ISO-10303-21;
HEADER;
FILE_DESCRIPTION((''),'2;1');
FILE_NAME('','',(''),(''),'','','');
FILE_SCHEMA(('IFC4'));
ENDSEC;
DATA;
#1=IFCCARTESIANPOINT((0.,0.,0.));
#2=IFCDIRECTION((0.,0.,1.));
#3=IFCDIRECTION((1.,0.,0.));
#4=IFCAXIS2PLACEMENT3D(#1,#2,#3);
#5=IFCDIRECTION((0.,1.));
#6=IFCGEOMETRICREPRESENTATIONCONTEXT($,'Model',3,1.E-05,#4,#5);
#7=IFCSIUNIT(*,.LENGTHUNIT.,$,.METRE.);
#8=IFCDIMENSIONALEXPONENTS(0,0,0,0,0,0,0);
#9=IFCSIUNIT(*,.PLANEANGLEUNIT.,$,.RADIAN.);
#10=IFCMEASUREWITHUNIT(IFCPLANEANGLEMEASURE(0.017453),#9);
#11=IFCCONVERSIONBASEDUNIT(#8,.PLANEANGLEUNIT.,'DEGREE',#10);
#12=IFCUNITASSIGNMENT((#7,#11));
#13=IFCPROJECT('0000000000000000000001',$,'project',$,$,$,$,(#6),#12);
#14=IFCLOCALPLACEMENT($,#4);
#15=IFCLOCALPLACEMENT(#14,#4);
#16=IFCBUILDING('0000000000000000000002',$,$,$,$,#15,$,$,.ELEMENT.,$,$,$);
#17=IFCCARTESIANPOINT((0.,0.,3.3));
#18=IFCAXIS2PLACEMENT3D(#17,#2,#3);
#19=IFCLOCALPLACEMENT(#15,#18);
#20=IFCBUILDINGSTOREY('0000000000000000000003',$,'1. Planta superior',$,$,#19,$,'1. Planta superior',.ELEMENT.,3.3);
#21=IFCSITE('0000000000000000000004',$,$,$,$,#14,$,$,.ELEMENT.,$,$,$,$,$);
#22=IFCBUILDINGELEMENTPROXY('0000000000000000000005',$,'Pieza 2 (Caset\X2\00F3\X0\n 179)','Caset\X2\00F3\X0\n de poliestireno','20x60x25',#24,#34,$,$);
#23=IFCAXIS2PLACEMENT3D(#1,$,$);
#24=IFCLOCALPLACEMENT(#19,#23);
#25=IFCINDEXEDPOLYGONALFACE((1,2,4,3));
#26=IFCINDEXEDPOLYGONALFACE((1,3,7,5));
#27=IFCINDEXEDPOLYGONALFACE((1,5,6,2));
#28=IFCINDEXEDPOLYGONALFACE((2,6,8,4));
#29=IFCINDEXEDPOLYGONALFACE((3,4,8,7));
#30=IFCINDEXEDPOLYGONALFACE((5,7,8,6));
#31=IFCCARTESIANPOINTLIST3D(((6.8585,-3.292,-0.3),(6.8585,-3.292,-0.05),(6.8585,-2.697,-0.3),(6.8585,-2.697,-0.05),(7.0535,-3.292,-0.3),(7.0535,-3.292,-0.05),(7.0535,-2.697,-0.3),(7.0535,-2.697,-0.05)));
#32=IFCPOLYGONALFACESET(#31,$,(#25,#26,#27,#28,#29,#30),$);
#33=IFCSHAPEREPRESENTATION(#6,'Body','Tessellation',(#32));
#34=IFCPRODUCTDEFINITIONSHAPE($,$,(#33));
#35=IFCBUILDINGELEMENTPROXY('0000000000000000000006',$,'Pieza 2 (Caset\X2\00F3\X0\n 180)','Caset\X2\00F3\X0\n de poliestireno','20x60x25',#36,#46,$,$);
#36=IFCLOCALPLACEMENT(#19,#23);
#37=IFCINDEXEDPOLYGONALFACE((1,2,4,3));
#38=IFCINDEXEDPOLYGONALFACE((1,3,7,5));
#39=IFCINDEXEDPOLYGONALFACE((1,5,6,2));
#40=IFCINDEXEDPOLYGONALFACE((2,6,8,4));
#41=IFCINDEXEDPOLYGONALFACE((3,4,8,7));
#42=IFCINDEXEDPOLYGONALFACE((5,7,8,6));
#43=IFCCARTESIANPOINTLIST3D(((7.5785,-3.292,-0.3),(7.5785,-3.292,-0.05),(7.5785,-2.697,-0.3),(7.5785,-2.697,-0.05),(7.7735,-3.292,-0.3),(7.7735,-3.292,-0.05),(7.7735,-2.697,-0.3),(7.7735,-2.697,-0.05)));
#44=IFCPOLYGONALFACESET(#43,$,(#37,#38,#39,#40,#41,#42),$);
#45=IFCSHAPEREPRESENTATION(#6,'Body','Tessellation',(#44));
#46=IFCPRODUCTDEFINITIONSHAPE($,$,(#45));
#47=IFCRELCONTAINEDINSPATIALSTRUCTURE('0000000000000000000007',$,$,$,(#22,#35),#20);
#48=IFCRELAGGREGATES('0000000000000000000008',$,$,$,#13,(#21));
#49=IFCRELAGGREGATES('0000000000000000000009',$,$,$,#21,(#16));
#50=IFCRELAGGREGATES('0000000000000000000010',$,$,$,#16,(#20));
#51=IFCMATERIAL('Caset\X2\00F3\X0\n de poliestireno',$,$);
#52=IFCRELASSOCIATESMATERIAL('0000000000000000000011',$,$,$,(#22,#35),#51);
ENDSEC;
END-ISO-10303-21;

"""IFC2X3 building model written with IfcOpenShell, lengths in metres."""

from ifc_helpers import new_model, entity, si_unit, converted_unit, direction, frame, origin_with_axes, origin_2d_with_axis, place, context, project, spatial, rectangle, extrude, source, transform, mapped, material, element, save


model = new_model("IFC2X3")

# Units and contexts
model_context = context("Model", 3, precision=1e-05, world=origin_with_axes(), true_north=direction((0.0, 1.0)))
ifc_project = project(units=[si_unit("LENGTHUNIT", "METRE"), converted_unit("PLANEANGLEUNIT", "DEGREE", entity("IfcPlaneAngleMeasure", 0.017453), si_unit("PLANEANGLEUNIT", "RADIAN"), dimensions=[0, 0, 0, 0, 0, 0, 0])], contexts=[model_context])

# Site, building, storey
site_placement = place(None, origin_with_axes())
site = spatial("IfcSite", under=ifc_project, at=site_placement, CompositionType="ELEMENT")
building_placement = place(site_placement, origin_with_axes())
building = spatial("IfcBuilding", under=site, at=building_placement, CompositionType="ELEMENT")
storey_placement = place(building_placement, frame((0.0, 0.0, 3.3), z_axis=(0.0, 0.0, 1.0), x_axis=(1.0, 0.0, 0.0)))
storey = spatial("IfcBuildingStorey", under=building, at=storey_placement, Name="1. Planta superior", LongName="1. Planta superior", CompositionType="ELEMENT", Elevation=3.3)

# Building element proxies
ifc_material_1 = material(Name="Casetón de poliestireno")
shared_shape = source(origin_with_axes(), model_context, "Body", "SweptSolid", [
    extrude(rectangle(XDim=0.195, YDim=0.25, at=origin_2d_with_axis()), origin_with_axes(), (0.0, 0.0, 1.0), 0.595),
])
placement_1 = place(storey_placement, frame((6.956, -3.292, -0.175), z_axis=(0.0, 1.0, 0.0), x_axis=(-1.0, 0.0, 0.0)))
for number, where, z_axis, x_axis, name in (
    (1, (0.0, 0.0, 0.0), (0.0, 0.0, 1.0), (1.0, 0.0, 0.0), "Pieza 2 (Casetón 179)"),
):
    element("IfcBuildingElementProxy", number, at=place(placement_1, frame(where, z_axis=z_axis, x_axis=x_axis)), inside=storey, material=ifc_material_1, Name=name, Description="Casetón de poliestireno", ObjectType="20x60x25", context=model_context, shape_type="MappedRepresentation", body=[
        mapped(shared_shape, transform((0.0, 0.0, 0.0), x_axis=(1.0, 0.0, 0.0), y_axis=(0.0, 1.0, 0.0), z_axis=(0.0, 0.0, 1.0))),
    ])
placement_2 = place(storey_placement, frame((7.676, -3.292, -0.175), z_axis=(0.0, 1.0, 0.0), x_axis=(-1.0, 0.0, 0.0)))
for number, where, z_axis, x_axis, name in (
    (2, (0.0, 0.0, 0.0), (0.0, 0.0, 1.0), (1.0, 0.0, 0.0), "Pieza 2 (Casetón 180)"),
):
    element("IfcBuildingElementProxy", number, at=place(placement_2, frame(where, z_axis=z_axis, x_axis=x_axis)), inside=storey, material=ifc_material_1, Name=name, Description="Casetón de poliestireno", ObjectType="20x60x25", context=model_context, shape_type="MappedRepresentation", body=[
        mapped(shared_shape, transform((0.0, 0.0, 0.0), x_axis=(1.0, 0.0, 0.0), y_axis=(0.0, 1.0, 0.0), z_axis=(0.0, 0.0, 1.0))),
    ])

save(model, "model.ifc")
